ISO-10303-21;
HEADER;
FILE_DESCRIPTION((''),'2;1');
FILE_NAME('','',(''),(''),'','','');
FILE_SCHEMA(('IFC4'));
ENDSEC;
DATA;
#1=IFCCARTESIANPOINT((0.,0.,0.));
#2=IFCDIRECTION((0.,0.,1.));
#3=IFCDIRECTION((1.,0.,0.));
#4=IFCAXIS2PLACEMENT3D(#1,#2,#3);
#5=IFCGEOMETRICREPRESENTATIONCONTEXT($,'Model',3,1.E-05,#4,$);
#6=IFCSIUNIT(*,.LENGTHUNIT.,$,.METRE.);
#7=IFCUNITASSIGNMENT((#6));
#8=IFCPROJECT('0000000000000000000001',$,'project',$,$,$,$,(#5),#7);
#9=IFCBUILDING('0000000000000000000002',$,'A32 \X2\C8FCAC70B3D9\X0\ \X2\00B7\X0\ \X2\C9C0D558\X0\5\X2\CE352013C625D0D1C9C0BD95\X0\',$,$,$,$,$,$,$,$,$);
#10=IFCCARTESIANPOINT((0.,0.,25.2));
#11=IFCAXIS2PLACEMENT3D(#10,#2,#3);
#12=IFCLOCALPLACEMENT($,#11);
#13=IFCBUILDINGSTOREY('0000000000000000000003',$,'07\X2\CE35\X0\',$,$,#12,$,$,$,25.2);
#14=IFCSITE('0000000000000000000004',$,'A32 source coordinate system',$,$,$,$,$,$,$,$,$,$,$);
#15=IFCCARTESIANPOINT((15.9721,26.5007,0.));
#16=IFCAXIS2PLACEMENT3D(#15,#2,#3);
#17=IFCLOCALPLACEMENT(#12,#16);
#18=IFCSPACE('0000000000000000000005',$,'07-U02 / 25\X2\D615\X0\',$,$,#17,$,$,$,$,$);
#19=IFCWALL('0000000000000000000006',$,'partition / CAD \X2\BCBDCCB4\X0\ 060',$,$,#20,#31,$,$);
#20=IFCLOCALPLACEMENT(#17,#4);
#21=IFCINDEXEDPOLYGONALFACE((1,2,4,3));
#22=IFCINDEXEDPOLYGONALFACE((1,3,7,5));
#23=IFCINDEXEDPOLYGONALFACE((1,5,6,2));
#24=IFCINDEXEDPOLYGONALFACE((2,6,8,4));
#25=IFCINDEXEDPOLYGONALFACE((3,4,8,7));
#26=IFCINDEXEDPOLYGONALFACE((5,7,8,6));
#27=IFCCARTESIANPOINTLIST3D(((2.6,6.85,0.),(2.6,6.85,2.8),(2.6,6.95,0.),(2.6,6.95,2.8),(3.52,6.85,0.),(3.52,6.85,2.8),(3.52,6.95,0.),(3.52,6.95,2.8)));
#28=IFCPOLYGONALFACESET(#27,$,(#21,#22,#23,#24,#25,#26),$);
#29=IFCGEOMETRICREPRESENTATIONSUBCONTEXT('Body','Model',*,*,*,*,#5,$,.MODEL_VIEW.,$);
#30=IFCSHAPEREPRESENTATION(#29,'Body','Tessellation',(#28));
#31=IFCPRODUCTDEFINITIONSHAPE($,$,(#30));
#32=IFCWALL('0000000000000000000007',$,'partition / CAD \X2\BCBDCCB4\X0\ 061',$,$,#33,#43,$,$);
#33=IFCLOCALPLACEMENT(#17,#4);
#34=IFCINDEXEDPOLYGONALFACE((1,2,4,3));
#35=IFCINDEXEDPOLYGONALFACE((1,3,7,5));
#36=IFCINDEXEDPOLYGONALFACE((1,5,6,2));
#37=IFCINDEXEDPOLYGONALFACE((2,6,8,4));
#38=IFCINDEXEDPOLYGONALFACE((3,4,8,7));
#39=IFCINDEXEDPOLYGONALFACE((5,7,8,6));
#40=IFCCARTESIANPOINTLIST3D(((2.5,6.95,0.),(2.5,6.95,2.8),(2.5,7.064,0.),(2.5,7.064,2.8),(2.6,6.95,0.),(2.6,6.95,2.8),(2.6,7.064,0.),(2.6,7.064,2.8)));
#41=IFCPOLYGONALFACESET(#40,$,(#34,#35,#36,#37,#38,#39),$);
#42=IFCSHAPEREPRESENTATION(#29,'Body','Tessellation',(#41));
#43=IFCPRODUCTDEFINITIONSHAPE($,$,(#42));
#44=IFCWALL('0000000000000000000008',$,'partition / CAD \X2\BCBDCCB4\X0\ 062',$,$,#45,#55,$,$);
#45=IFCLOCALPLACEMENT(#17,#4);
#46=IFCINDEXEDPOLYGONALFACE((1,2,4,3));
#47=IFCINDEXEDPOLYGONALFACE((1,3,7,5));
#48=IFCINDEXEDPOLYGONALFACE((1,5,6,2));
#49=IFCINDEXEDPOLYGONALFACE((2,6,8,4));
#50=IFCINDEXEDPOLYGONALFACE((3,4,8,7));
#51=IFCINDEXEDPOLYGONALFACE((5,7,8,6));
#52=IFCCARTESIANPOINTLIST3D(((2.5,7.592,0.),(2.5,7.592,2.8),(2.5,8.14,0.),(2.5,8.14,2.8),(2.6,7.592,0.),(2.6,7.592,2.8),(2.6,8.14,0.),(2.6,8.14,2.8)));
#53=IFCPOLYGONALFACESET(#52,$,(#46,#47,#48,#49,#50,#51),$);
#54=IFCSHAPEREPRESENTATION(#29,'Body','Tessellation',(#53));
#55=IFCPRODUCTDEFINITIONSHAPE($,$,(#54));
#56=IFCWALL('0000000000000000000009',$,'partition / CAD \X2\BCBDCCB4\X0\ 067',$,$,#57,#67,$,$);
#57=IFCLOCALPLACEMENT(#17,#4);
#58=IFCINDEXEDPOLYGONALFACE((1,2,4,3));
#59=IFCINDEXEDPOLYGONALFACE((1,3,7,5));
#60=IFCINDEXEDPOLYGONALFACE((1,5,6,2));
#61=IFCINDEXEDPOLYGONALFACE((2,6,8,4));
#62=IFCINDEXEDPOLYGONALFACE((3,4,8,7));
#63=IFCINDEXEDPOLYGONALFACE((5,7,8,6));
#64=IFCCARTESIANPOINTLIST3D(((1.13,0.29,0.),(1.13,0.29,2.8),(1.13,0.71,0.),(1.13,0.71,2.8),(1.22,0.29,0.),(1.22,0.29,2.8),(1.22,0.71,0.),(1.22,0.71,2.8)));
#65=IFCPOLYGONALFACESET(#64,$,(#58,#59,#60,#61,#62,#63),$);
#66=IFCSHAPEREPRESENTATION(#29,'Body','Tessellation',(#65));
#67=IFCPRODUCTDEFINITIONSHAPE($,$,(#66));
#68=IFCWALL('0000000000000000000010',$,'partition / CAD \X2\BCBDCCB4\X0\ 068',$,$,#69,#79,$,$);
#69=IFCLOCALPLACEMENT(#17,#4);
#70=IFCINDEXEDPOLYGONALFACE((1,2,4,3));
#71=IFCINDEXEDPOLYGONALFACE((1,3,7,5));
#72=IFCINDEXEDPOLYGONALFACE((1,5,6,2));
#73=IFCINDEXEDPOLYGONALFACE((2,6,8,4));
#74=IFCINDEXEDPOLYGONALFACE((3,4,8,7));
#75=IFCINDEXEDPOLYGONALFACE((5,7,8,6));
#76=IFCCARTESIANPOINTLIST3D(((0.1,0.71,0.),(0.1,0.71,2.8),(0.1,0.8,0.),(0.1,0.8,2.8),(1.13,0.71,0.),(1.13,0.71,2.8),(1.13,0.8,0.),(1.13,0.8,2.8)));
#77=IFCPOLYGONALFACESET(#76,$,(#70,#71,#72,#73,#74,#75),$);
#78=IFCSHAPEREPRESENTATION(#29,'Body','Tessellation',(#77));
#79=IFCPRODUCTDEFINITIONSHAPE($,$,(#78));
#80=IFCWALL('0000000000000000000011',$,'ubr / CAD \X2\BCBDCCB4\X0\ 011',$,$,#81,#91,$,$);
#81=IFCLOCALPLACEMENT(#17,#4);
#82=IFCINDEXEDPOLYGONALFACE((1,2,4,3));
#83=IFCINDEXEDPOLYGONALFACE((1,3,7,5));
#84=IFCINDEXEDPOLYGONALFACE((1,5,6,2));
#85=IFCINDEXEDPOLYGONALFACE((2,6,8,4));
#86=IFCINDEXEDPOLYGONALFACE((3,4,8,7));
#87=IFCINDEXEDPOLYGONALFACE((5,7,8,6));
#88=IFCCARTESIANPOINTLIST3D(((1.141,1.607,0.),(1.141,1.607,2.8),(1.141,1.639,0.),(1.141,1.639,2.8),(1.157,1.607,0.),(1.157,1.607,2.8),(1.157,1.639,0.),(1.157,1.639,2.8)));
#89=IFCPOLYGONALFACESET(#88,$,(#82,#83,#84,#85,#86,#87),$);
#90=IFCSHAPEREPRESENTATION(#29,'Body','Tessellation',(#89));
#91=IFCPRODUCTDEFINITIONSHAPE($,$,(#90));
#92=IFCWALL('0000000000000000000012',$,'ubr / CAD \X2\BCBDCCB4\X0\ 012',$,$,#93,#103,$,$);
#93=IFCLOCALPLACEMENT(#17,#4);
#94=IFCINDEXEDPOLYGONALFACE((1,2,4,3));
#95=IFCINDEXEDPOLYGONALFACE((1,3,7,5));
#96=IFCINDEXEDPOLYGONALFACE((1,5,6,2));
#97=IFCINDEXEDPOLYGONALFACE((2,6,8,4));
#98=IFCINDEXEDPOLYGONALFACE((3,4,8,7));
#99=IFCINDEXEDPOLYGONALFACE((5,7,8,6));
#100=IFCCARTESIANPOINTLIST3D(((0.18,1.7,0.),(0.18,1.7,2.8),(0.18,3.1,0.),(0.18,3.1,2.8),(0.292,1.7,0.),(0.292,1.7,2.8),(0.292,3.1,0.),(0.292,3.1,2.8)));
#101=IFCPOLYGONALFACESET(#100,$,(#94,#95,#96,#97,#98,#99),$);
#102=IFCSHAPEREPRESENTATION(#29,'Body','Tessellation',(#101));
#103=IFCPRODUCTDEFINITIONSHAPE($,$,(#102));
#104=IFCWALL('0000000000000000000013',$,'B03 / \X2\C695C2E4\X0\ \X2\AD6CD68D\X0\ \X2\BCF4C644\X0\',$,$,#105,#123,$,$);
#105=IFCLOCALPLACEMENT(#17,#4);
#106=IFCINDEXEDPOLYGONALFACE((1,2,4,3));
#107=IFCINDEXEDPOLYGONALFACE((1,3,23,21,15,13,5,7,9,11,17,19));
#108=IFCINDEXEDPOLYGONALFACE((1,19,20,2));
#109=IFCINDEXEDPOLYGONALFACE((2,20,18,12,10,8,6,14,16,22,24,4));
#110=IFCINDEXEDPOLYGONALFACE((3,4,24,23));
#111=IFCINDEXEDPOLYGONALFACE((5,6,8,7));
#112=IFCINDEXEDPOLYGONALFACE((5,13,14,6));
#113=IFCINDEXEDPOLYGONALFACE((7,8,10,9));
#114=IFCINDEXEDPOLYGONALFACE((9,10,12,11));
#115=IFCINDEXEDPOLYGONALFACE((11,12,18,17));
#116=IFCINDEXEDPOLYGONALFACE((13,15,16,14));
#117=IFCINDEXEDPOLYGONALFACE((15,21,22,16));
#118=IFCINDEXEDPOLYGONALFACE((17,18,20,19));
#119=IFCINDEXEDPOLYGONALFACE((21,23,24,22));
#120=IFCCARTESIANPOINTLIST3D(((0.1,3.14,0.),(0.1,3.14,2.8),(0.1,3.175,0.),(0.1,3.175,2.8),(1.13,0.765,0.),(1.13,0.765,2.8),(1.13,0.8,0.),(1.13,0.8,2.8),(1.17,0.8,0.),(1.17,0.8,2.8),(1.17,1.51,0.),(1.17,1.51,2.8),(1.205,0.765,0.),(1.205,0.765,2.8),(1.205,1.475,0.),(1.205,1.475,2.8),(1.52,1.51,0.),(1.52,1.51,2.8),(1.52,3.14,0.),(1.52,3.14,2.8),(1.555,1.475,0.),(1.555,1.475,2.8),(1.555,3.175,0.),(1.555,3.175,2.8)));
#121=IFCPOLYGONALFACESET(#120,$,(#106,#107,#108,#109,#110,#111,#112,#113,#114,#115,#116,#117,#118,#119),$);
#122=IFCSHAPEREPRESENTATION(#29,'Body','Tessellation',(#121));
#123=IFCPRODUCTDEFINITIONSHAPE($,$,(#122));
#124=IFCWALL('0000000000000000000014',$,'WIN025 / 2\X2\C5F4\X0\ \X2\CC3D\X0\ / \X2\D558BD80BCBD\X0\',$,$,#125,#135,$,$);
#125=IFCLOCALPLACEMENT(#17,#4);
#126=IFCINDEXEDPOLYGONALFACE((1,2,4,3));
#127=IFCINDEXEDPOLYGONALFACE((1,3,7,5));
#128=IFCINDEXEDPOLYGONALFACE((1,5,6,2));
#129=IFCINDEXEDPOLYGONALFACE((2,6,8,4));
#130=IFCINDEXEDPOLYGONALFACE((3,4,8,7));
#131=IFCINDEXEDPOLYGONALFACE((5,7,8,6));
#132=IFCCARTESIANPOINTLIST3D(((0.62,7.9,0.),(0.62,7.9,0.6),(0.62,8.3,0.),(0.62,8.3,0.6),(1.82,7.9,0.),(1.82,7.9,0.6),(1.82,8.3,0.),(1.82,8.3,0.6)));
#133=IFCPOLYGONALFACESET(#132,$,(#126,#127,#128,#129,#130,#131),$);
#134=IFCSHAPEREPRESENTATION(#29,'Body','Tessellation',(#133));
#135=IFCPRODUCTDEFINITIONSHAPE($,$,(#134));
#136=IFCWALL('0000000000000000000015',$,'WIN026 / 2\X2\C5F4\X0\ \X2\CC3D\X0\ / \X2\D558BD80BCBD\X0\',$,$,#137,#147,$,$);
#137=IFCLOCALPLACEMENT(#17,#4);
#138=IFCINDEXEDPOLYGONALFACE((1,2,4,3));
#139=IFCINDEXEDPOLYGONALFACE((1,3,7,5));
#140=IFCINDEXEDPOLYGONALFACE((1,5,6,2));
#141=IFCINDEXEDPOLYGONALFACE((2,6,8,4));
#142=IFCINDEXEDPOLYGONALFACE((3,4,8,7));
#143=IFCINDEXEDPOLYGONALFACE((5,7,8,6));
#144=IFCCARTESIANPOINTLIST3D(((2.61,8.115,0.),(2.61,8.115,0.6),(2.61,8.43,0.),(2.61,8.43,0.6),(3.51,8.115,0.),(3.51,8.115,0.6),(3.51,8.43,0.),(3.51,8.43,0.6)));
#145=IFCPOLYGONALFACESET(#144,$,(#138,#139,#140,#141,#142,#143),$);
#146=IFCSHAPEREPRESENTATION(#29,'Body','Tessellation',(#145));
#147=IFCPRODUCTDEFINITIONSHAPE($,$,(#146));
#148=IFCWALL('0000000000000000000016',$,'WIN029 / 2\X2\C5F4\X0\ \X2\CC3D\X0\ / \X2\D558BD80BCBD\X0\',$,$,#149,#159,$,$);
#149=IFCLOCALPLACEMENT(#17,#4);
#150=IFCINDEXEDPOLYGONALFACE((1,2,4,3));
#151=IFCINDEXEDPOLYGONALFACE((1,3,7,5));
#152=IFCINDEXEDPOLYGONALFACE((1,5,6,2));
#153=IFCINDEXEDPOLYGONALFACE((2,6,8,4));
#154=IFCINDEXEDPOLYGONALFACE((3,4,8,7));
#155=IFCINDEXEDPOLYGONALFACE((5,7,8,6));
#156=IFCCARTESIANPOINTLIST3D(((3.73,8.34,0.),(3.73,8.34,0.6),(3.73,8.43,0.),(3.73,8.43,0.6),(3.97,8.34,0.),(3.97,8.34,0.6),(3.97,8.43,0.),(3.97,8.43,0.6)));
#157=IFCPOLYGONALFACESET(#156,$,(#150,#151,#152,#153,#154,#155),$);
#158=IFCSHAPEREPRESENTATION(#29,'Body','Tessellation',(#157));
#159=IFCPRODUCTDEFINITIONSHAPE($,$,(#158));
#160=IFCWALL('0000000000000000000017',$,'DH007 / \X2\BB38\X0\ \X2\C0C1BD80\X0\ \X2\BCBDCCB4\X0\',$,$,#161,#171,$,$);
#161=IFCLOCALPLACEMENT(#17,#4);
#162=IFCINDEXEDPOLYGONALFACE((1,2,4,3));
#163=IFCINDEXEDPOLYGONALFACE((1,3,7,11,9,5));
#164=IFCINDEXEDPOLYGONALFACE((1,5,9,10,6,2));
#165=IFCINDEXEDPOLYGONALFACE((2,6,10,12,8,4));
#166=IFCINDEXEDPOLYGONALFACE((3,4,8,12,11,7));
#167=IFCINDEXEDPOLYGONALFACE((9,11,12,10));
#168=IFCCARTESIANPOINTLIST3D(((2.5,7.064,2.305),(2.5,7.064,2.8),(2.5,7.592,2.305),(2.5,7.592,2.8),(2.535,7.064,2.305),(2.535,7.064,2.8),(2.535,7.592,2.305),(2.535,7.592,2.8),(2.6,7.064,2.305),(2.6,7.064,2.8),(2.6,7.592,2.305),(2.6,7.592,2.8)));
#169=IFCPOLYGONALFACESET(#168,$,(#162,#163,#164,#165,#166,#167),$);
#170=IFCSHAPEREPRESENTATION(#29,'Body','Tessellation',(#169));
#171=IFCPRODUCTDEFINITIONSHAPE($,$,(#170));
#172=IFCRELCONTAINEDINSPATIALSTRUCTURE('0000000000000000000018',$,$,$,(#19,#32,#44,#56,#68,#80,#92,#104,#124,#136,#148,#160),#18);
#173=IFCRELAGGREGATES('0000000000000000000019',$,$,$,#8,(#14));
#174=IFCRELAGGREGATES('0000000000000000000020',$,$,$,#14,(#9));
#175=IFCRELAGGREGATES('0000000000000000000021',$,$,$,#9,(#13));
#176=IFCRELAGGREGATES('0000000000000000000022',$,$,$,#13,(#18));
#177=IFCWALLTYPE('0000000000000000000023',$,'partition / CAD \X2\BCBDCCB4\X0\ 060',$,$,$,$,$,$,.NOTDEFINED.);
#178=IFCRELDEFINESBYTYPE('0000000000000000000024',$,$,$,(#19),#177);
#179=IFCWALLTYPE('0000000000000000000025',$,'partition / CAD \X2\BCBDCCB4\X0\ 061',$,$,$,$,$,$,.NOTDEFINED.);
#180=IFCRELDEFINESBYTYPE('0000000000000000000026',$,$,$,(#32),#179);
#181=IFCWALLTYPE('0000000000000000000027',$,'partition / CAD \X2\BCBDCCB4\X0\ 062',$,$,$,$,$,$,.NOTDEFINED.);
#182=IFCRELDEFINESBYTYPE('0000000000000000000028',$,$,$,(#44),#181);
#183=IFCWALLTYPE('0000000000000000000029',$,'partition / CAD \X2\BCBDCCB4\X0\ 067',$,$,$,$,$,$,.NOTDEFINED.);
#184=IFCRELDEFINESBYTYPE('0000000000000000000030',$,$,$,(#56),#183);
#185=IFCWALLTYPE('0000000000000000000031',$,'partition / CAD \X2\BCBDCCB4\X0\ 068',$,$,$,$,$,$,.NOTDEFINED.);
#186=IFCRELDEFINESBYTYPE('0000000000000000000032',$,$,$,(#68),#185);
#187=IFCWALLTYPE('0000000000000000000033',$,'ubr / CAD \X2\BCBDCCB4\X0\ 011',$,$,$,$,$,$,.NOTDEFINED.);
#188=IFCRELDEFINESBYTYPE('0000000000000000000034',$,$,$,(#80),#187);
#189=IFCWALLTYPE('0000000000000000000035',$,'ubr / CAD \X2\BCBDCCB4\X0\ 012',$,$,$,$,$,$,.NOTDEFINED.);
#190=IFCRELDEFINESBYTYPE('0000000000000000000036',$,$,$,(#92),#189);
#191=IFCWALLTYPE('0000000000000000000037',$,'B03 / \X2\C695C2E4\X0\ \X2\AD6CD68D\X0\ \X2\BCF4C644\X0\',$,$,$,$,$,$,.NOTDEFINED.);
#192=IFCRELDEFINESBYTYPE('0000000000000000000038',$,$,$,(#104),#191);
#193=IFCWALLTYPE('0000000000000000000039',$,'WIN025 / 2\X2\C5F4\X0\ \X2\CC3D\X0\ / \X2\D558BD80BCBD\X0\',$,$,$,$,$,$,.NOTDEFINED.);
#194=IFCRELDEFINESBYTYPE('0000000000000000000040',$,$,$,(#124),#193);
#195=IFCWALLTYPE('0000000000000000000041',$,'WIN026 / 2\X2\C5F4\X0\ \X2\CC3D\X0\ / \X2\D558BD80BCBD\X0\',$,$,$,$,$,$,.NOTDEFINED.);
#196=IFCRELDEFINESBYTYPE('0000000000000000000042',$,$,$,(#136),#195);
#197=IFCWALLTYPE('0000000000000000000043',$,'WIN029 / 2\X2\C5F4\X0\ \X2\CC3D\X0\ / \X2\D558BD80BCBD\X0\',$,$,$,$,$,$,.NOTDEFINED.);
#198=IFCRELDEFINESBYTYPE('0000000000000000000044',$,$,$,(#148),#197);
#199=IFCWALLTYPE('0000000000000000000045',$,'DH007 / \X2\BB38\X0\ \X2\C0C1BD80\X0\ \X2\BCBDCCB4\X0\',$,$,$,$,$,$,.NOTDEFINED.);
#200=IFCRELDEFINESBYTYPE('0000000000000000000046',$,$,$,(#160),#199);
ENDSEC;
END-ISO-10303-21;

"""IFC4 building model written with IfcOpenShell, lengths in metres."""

from ifc_helpers import new_model, si_unit, frame, origin, origin_with_axes, place, context, subcontext, project, spatial, polyline, outline, extrude, source, transform, mapped, type_object, type_shapes, element, save


model = new_model("IFC4")

# Units and contexts
model_context = context("Model", 3, precision=1e-05, world=origin_with_axes())
body_context = subcontext(model_context, "Body", "Model", "MODEL_VIEW")
ifc_project = project(units=[si_unit("LENGTHUNIT", "METRE")], contexts=[model_context])

# Site, building, storey, space
site = spatial("IfcSite", under=ifc_project, Name="A32 source coordinate system")
building = spatial("IfcBuilding", under=site, Name="A32 주거동 · 지하5층–옥탑지붕")
storey_placement = place(None, frame((0.0, 0.0, 25.2), z_axis=(0.0, 0.0, 1.0), x_axis=(1.0, 0.0, 0.0)))
storey = spatial("IfcBuildingStorey", under=building, at=storey_placement, Name="07층", Elevation=25.2)
space_1_placement = place(storey_placement, frame((15.9721, 26.5007, 0.0), z_axis=(0.0, 0.0, 1.0), x_axis=(1.0, 0.0, 0.0)))
space_1 = spatial("IfcSpace", under=storey, at=space_1_placement, Name="07-U02 / 25형")

# Walls
wall_type_1 = type_object("IfcWallType", Name="partition / CAD 벽체 060", PredefinedType="NOTDEFINED")
shared_shape_1 = source(origin(), body_context, "Body", "SweptSolid", [
    extrude(outline(polyline([(3.52, 6.85), (2.6, 6.85), (2.6, 6.95), (3.52, 6.95), (3.52, 6.85)])), origin(), (0.0, 0.0, 1.0), 2.8),
])
type_shapes(wall_type_1, [shared_shape_1])
wall_1_placement = place(space_1_placement, origin_with_axes())
element("IfcWall", 1, at=wall_1_placement, inside=space_1, type_object=wall_type_1, Name="partition / CAD 벽체 060", context=body_context, shape_type="MappedRepresentation", body=[
    mapped(shared_shape_1, transform((0.0, 0.0, 0.0), scale=1.0)),
])
wall_type_2 = type_object("IfcWallType", Name="partition / CAD 벽체 061", PredefinedType="NOTDEFINED")
shared_shape_2 = source(origin(), body_context, "Body", "SweptSolid", [
    extrude(outline(polyline([(2.6, 7.064), (2.6, 6.95), (2.5, 6.95), (2.5, 7.064), (2.6, 7.064)])), origin(), (0.0, 0.0, 1.0), 2.8),
])
type_shapes(wall_type_2, [shared_shape_2])
wall_2_placement = place(space_1_placement, origin_with_axes())
element("IfcWall", 2, at=wall_2_placement, inside=space_1, type_object=wall_type_2, Name="partition / CAD 벽체 061", context=body_context, shape_type="MappedRepresentation", body=[
    mapped(shared_shape_2, transform((0.0, 0.0, 0.0), scale=1.0)),
])
wall_type_3 = type_object("IfcWallType", Name="partition / CAD 벽체 062", PredefinedType="NOTDEFINED")
shared_shape_3 = source(origin(), body_context, "Body", "SweptSolid", [
    extrude(outline(polyline([(2.5, 7.592), (2.5, 8.14), (2.6, 8.14), (2.6, 7.592), (2.5, 7.592)])), origin(), (0.0, 0.0, 1.0), 2.8),
])
type_shapes(wall_type_3, [shared_shape_3])
wall_3_placement = place(space_1_placement, origin_with_axes())
element("IfcWall", 3, at=wall_3_placement, inside=space_1, type_object=wall_type_3, Name="partition / CAD 벽체 062", context=body_context, shape_type="MappedRepresentation", body=[
    mapped(shared_shape_3, transform((0.0, 0.0, 0.0), scale=1.0)),
])
wall_type_4 = type_object("IfcWallType", Name="partition / CAD 벽체 067", PredefinedType="NOTDEFINED")
shared_shape_4 = source(origin(), body_context, "Body", "SweptSolid", [
    extrude(outline(polyline([(1.22, 0.71), (1.22, 0.29), (1.13, 0.29), (1.13, 0.71), (1.22, 0.71)])), origin(), (0.0, 0.0, 1.0), 2.8),
])
type_shapes(wall_type_4, [shared_shape_4])
wall_4_placement = place(space_1_placement, origin_with_axes())
element("IfcWall", 4, at=wall_4_placement, inside=space_1, type_object=wall_type_4, Name="partition / CAD 벽체 067", context=body_context, shape_type="MappedRepresentation", body=[
    mapped(shared_shape_4, transform((0.0, 0.0, 0.0), scale=1.0)),
])
wall_type_5 = type_object("IfcWallType", Name="partition / CAD 벽체 068", PredefinedType="NOTDEFINED")
shared_shape_5 = source(origin(), body_context, "Body", "SweptSolid", [
    extrude(outline(polyline([(1.13, 0.8), (1.13, 0.71), (0.1, 0.71), (0.1, 0.8), (1.13, 0.8)])), origin(), (0.0, 0.0, 1.0), 2.8),
])
type_shapes(wall_type_5, [shared_shape_5])
wall_5_placement = place(space_1_placement, origin_with_axes())
element("IfcWall", 5, at=wall_5_placement, inside=space_1, type_object=wall_type_5, Name="partition / CAD 벽체 068", context=body_context, shape_type="MappedRepresentation", body=[
    mapped(shared_shape_5, transform((0.0, 0.0, 0.0), scale=1.0)),
])
wall_type_6 = type_object("IfcWallType", Name="ubr / CAD 벽체 011", PredefinedType="NOTDEFINED")
shared_shape_6 = source(origin(), body_context, "Body", "SweptSolid", [
    extrude(outline(polyline([(1.141, 1.607), (1.141, 1.639), (1.157, 1.639), (1.157, 1.607), (1.141, 1.607)])), origin(), (0.0, 0.0, 1.0), 2.8),
])
type_shapes(wall_type_6, [shared_shape_6])
wall_6_placement = place(space_1_placement, origin_with_axes())
element("IfcWall", 6, at=wall_6_placement, inside=space_1, type_object=wall_type_6, Name="ubr / CAD 벽체 011", context=body_context, shape_type="MappedRepresentation", body=[
    mapped(shared_shape_6, transform((0.0, 0.0, 0.0), scale=1.0)),
])
wall_type_7 = type_object("IfcWallType", Name="ubr / CAD 벽체 012", PredefinedType="NOTDEFINED")
shared_shape_7 = source(origin(), body_context, "Body", "SweptSolid", [
    extrude(outline(polyline([(0.18, 1.7), (0.18, 3.1), (0.292, 3.1), (0.292, 1.7), (0.18, 1.7)])), origin(), (0.0, 0.0, 1.0), 2.8),
])
type_shapes(wall_type_7, [shared_shape_7])
wall_7_placement = place(space_1_placement, origin_with_axes())
element("IfcWall", 7, at=wall_7_placement, inside=space_1, type_object=wall_type_7, Name="ubr / CAD 벽체 012", context=body_context, shape_type="MappedRepresentation", body=[
    mapped(shared_shape_7, transform((0.0, 0.0, 0.0), scale=1.0)),
])
wall_type_8 = type_object("IfcWallType", Name="B03 / 욕실 구획 보완", PredefinedType="NOTDEFINED")
shared_shape_8 = source(origin(), body_context, "Body", "SweptSolid", [
    extrude(outline(polyline([(1.13, 0.765), (1.13, 0.8), (1.17, 0.8), (1.17, 1.51), (1.52, 1.51), (1.52, 3.14), (0.1, 3.14), (0.1, 3.175), (1.555, 3.175), (1.555, 1.475), (1.205, 1.475), (1.205, 0.765), (1.13, 0.765)])), origin(), (0.0, 0.0, 1.0), 2.8),
])
type_shapes(wall_type_8, [shared_shape_8])
wall_8_placement = place(space_1_placement, origin_with_axes())
element("IfcWall", 8, at=wall_8_placement, inside=space_1, type_object=wall_type_8, Name="B03 / 욕실 구획 보완", context=body_context, shape_type="MappedRepresentation", body=[
    mapped(shared_shape_8, transform((0.0, 0.0, 0.0), scale=1.0)),
])
wall_type_9 = type_object("IfcWallType", Name="WIN025 / 2열 창 / 하부벽", PredefinedType="NOTDEFINED")
shared_shape_9 = source(origin(), body_context, "Body", "SweptSolid", [
    extrude(outline(polyline([(1.82, 8.3), (1.82, 7.9), (0.62, 7.9), (0.62, 8.3), (1.82, 8.3)])), origin(), (0.0, 0.0, 1.0), 0.6),
])
type_shapes(wall_type_9, [shared_shape_9])
wall_9_placement = place(space_1_placement, origin_with_axes())
element("IfcWall", 9, at=wall_9_placement, inside=space_1, type_object=wall_type_9, Name="WIN025 / 2열 창 / 하부벽", context=body_context, shape_type="MappedRepresentation", body=[
    mapped(shared_shape_9, transform((0.0, 0.0, 0.0), scale=1.0)),
])
wall_type_10 = type_object("IfcWallType", Name="WIN026 / 2열 창 / 하부벽", PredefinedType="NOTDEFINED")
shared_shape_10 = source(origin(), body_context, "Body", "SweptSolid", [
    extrude(outline(polyline([(3.51, 8.43), (3.51, 8.115), (2.61, 8.115), (2.61, 8.43), (3.51, 8.43)])), origin(), (0.0, 0.0, 1.0), 0.6),
])
type_shapes(wall_type_10, [shared_shape_10])
wall_10_placement = place(space_1_placement, origin_with_axes())
element("IfcWall", 10, at=wall_10_placement, inside=space_1, type_object=wall_type_10, Name="WIN026 / 2열 창 / 하부벽", context=body_context, shape_type="MappedRepresentation", body=[
    mapped(shared_shape_10, transform((0.0, 0.0, 0.0), scale=1.0)),
])
wall_type_11 = type_object("IfcWallType", Name="WIN029 / 2열 창 / 하부벽", PredefinedType="NOTDEFINED")
shared_shape_11 = source(origin(), body_context, "Body", "SweptSolid", [
    extrude(outline(polyline([(3.97, 8.43), (3.97, 8.34), (3.73, 8.34), (3.73, 8.43), (3.97, 8.43)])), origin(), (0.0, 0.0, 1.0), 0.6),
])
type_shapes(wall_type_11, [shared_shape_11])
wall_11_placement = place(space_1_placement, origin_with_axes())
element("IfcWall", 11, at=wall_11_placement, inside=space_1, type_object=wall_type_11, Name="WIN029 / 2열 창 / 하부벽", context=body_context, shape_type="MappedRepresentation", body=[
    mapped(shared_shape_11, transform((0.0, 0.0, 0.0), scale=1.0)),
])
wall_type_12 = type_object("IfcWallType", Name="DH007 / 문 상부 벽체", PredefinedType="NOTDEFINED")
shared_shape_12 = source(origin(), body_context, "Body", "SweptSolid", [
    extrude(outline(polyline([(2.5, 7.592), (2.535, 7.592), (2.6, 7.592), (2.6, 7.064), (2.535, 7.064), (2.5, 7.064), (2.5, 7.592)])), frame((0.0, 0.0, 2.305)), (0.0, 0.0, 1.0), 0.495),
])
type_shapes(wall_type_12, [shared_shape_12])
wall_12_placement = place(space_1_placement, origin_with_axes())
element("IfcWall", 12, at=wall_12_placement, inside=space_1, type_object=wall_type_12, Name="DH007 / 문 상부 벽체", context=body_context, shape_type="MappedRepresentation", body=[
    mapped(shared_shape_12, transform((0.0, 0.0, 0.0), scale=1.0)),
])

save(model, "model.ifc")
